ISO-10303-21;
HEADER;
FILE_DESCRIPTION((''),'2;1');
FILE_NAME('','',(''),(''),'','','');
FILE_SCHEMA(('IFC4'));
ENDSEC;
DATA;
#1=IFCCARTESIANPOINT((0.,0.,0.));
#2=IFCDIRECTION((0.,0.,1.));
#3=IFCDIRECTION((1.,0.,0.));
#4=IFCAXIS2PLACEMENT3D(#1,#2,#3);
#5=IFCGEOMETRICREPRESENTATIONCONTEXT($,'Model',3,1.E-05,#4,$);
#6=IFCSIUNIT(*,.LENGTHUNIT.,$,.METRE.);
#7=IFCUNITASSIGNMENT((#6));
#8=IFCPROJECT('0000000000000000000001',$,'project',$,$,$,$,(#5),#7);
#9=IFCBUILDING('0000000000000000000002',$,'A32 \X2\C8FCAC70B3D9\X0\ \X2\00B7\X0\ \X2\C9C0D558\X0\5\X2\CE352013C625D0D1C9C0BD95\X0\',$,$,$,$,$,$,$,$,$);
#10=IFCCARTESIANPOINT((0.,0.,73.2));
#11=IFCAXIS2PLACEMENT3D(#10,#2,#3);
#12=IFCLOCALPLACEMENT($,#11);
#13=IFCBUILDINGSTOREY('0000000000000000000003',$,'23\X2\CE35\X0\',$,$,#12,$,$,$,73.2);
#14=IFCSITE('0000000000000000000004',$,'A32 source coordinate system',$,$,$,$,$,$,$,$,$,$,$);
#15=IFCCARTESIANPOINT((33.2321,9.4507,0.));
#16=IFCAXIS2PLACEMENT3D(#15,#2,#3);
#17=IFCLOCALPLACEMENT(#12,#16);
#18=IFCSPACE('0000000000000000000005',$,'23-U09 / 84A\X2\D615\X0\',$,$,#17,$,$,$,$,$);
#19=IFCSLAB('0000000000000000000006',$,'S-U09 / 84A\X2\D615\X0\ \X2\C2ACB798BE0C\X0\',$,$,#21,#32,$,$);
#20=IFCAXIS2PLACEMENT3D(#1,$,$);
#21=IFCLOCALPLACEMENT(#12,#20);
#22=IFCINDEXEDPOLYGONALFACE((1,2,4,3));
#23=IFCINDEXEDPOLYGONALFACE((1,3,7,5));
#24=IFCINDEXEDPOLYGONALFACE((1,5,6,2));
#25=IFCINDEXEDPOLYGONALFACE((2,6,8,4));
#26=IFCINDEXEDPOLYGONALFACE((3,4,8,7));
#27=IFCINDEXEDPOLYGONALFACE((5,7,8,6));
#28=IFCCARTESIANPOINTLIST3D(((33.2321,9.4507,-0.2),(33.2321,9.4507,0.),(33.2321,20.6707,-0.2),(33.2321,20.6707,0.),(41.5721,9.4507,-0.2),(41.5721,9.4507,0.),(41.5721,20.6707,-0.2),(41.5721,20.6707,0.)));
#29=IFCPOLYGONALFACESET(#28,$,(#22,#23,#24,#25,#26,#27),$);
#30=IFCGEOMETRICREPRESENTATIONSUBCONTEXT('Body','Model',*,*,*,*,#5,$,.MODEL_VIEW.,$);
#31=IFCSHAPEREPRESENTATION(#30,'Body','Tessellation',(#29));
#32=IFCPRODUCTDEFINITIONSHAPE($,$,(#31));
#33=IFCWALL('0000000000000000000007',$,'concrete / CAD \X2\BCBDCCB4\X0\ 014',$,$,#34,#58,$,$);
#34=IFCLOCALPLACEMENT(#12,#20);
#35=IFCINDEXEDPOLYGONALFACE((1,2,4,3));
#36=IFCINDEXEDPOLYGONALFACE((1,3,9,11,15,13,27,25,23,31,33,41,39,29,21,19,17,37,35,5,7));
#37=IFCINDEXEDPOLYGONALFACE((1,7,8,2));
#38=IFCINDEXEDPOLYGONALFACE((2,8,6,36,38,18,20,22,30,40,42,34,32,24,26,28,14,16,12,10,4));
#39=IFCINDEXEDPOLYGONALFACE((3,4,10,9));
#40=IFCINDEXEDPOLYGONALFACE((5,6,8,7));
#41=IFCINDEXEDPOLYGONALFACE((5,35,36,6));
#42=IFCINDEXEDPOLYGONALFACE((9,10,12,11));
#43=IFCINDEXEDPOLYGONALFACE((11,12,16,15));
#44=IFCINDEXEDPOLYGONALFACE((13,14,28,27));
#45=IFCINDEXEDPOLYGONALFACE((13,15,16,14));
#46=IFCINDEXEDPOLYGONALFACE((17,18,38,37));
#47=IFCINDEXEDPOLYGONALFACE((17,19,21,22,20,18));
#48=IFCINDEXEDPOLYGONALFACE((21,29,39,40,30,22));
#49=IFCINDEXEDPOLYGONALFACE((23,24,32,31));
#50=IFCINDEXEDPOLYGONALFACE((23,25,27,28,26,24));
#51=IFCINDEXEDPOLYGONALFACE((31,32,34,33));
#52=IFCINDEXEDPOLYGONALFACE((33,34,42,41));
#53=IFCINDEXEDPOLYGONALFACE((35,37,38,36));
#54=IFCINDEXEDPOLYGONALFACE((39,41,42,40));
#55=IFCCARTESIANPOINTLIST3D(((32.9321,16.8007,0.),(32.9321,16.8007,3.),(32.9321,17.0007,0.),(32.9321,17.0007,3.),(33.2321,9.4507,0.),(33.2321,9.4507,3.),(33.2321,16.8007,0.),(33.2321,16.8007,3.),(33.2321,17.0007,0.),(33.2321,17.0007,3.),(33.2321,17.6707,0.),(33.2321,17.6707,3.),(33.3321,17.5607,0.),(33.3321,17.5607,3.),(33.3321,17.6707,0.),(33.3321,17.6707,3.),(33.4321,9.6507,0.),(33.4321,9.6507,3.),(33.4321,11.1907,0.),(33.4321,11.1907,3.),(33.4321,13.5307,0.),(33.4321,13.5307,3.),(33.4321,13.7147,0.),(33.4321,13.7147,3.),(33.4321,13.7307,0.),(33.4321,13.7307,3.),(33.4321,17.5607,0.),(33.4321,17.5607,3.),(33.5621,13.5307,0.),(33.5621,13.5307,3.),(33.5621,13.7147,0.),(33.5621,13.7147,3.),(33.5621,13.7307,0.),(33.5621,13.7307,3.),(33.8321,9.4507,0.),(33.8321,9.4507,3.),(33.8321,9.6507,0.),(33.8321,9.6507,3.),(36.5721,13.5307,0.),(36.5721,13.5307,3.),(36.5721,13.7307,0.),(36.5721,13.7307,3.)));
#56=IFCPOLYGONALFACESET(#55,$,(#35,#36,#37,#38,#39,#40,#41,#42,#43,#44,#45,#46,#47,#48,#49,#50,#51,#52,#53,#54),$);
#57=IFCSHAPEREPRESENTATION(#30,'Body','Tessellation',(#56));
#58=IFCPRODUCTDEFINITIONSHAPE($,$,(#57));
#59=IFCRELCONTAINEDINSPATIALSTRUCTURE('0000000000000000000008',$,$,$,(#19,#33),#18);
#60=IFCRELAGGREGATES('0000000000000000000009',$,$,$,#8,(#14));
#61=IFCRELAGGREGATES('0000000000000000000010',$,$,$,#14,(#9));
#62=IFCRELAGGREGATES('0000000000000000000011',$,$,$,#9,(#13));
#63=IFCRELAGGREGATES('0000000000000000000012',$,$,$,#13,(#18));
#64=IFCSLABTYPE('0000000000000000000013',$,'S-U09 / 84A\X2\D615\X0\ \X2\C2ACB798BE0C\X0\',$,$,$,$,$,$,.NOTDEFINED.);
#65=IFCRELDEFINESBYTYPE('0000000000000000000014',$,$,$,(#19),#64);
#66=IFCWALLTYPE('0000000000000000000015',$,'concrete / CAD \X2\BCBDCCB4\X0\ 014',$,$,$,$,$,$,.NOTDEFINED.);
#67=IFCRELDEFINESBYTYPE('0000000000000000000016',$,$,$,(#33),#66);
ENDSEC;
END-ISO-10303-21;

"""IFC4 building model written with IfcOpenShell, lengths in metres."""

from ifc_helpers import new_model, si_unit, frame, origin, origin_with_axes, place, context, subcontext, project, spatial, polyline, outline, extrude, source, transform, mapped, type_object, type_shapes, element, save


model = new_model("IFC4")

# Units and contexts
model_context = context("Model", 3, precision=1e-05, world=origin_with_axes())
body_context = subcontext(model_context, "Body", "Model", "MODEL_VIEW")
ifc_project = project(units=[si_unit("LENGTHUNIT", "METRE")], contexts=[model_context])

# Site, building, storey, space
site = spatial("IfcSite", under=ifc_project, Name="A32 source coordinate system")
building = spatial("IfcBuilding", under=site, Name="A32 주거동 · 지하5층–옥탑지붕")
storey_placement = place(None, frame((0.0, 0.0, 73.2), z_axis=(0.0, 0.0, 1.0), x_axis=(1.0, 0.0, 0.0)))
storey = spatial("IfcBuildingStorey", under=building, at=storey_placement, Name="23층", Elevation=73.2)
space_placement = place(storey_placement, frame((33.2321, 9.4507, 0.0), z_axis=(0.0, 0.0, 1.0), x_axis=(1.0, 0.0, 0.0)))
space = spatial("IfcSpace", under=storey, at=space_placement, Name="23-U09 / 84A형")

# Slab
slab_type_1 = type_object("IfcSlabType", Name="S-U09 / 84A형 슬래브", PredefinedType="NOTDEFINED")
shared_shape_1 = source(origin(), body_context, "Body", "SweptSolid", [
    extrude(outline(polyline([(0.0, 11.22), (8.34, 11.22), (8.34, 0.0), (0.0, 0.0), (0.0, 11.22)])), frame((0.0, 0.0, -0.2)), (0.0, 0.0, 1.0), 0.2),
])
type_shapes(slab_type_1, [shared_shape_1])
slab_1_placement = place(space_placement, origin_with_axes())
element("IfcSlab", 1, at=slab_1_placement, inside=space, type_object=slab_type_1, Name="S-U09 / 84A형 슬래브", context=body_context, shape_type="MappedRepresentation", body=[
    mapped(shared_shape_1, transform((0.0, 0.0, 0.0), scale=1.0)),
])

# Wall
wall_type_1 = type_object("IfcWallType", Name="concrete / CAD 벽체 014", PredefinedType="NOTDEFINED")
shared_shape_2 = source(origin(), body_context, "Body", "SweptSolid", [
    extrude(outline(polyline([(3.34, 4.08), (0.33, 4.08), (0.2, 4.08), (0.2, 1.74), (0.2, 0.2), (0.6, 0.2), (0.6, 0.0), (0.0, 0.0), (0.0, 7.35), (-0.3, 7.35), (-0.3, 7.55), (0.0, 7.55), (0.0, 8.22), (0.1, 8.22), (0.1, 8.11), (0.2, 8.11), (0.2, 4.28), (0.2, 4.264), (0.33, 4.264), (0.33, 4.28), (3.34, 4.28), (3.34, 4.08)])), origin(), (0.0, 0.0, 1.0), 3.0),
])
type_shapes(wall_type_1, [shared_shape_2])
wall_1_placement = place(space_placement, origin_with_axes())
element("IfcWall", 2, at=wall_1_placement, inside=space, type_object=wall_type_1, Name="concrete / CAD 벽체 014", context=body_context, shape_type="MappedRepresentation", body=[
    mapped(shared_shape_2, transform((0.0, 0.0, 0.0), scale=1.0)),
])

save(model, "model.ifc")
